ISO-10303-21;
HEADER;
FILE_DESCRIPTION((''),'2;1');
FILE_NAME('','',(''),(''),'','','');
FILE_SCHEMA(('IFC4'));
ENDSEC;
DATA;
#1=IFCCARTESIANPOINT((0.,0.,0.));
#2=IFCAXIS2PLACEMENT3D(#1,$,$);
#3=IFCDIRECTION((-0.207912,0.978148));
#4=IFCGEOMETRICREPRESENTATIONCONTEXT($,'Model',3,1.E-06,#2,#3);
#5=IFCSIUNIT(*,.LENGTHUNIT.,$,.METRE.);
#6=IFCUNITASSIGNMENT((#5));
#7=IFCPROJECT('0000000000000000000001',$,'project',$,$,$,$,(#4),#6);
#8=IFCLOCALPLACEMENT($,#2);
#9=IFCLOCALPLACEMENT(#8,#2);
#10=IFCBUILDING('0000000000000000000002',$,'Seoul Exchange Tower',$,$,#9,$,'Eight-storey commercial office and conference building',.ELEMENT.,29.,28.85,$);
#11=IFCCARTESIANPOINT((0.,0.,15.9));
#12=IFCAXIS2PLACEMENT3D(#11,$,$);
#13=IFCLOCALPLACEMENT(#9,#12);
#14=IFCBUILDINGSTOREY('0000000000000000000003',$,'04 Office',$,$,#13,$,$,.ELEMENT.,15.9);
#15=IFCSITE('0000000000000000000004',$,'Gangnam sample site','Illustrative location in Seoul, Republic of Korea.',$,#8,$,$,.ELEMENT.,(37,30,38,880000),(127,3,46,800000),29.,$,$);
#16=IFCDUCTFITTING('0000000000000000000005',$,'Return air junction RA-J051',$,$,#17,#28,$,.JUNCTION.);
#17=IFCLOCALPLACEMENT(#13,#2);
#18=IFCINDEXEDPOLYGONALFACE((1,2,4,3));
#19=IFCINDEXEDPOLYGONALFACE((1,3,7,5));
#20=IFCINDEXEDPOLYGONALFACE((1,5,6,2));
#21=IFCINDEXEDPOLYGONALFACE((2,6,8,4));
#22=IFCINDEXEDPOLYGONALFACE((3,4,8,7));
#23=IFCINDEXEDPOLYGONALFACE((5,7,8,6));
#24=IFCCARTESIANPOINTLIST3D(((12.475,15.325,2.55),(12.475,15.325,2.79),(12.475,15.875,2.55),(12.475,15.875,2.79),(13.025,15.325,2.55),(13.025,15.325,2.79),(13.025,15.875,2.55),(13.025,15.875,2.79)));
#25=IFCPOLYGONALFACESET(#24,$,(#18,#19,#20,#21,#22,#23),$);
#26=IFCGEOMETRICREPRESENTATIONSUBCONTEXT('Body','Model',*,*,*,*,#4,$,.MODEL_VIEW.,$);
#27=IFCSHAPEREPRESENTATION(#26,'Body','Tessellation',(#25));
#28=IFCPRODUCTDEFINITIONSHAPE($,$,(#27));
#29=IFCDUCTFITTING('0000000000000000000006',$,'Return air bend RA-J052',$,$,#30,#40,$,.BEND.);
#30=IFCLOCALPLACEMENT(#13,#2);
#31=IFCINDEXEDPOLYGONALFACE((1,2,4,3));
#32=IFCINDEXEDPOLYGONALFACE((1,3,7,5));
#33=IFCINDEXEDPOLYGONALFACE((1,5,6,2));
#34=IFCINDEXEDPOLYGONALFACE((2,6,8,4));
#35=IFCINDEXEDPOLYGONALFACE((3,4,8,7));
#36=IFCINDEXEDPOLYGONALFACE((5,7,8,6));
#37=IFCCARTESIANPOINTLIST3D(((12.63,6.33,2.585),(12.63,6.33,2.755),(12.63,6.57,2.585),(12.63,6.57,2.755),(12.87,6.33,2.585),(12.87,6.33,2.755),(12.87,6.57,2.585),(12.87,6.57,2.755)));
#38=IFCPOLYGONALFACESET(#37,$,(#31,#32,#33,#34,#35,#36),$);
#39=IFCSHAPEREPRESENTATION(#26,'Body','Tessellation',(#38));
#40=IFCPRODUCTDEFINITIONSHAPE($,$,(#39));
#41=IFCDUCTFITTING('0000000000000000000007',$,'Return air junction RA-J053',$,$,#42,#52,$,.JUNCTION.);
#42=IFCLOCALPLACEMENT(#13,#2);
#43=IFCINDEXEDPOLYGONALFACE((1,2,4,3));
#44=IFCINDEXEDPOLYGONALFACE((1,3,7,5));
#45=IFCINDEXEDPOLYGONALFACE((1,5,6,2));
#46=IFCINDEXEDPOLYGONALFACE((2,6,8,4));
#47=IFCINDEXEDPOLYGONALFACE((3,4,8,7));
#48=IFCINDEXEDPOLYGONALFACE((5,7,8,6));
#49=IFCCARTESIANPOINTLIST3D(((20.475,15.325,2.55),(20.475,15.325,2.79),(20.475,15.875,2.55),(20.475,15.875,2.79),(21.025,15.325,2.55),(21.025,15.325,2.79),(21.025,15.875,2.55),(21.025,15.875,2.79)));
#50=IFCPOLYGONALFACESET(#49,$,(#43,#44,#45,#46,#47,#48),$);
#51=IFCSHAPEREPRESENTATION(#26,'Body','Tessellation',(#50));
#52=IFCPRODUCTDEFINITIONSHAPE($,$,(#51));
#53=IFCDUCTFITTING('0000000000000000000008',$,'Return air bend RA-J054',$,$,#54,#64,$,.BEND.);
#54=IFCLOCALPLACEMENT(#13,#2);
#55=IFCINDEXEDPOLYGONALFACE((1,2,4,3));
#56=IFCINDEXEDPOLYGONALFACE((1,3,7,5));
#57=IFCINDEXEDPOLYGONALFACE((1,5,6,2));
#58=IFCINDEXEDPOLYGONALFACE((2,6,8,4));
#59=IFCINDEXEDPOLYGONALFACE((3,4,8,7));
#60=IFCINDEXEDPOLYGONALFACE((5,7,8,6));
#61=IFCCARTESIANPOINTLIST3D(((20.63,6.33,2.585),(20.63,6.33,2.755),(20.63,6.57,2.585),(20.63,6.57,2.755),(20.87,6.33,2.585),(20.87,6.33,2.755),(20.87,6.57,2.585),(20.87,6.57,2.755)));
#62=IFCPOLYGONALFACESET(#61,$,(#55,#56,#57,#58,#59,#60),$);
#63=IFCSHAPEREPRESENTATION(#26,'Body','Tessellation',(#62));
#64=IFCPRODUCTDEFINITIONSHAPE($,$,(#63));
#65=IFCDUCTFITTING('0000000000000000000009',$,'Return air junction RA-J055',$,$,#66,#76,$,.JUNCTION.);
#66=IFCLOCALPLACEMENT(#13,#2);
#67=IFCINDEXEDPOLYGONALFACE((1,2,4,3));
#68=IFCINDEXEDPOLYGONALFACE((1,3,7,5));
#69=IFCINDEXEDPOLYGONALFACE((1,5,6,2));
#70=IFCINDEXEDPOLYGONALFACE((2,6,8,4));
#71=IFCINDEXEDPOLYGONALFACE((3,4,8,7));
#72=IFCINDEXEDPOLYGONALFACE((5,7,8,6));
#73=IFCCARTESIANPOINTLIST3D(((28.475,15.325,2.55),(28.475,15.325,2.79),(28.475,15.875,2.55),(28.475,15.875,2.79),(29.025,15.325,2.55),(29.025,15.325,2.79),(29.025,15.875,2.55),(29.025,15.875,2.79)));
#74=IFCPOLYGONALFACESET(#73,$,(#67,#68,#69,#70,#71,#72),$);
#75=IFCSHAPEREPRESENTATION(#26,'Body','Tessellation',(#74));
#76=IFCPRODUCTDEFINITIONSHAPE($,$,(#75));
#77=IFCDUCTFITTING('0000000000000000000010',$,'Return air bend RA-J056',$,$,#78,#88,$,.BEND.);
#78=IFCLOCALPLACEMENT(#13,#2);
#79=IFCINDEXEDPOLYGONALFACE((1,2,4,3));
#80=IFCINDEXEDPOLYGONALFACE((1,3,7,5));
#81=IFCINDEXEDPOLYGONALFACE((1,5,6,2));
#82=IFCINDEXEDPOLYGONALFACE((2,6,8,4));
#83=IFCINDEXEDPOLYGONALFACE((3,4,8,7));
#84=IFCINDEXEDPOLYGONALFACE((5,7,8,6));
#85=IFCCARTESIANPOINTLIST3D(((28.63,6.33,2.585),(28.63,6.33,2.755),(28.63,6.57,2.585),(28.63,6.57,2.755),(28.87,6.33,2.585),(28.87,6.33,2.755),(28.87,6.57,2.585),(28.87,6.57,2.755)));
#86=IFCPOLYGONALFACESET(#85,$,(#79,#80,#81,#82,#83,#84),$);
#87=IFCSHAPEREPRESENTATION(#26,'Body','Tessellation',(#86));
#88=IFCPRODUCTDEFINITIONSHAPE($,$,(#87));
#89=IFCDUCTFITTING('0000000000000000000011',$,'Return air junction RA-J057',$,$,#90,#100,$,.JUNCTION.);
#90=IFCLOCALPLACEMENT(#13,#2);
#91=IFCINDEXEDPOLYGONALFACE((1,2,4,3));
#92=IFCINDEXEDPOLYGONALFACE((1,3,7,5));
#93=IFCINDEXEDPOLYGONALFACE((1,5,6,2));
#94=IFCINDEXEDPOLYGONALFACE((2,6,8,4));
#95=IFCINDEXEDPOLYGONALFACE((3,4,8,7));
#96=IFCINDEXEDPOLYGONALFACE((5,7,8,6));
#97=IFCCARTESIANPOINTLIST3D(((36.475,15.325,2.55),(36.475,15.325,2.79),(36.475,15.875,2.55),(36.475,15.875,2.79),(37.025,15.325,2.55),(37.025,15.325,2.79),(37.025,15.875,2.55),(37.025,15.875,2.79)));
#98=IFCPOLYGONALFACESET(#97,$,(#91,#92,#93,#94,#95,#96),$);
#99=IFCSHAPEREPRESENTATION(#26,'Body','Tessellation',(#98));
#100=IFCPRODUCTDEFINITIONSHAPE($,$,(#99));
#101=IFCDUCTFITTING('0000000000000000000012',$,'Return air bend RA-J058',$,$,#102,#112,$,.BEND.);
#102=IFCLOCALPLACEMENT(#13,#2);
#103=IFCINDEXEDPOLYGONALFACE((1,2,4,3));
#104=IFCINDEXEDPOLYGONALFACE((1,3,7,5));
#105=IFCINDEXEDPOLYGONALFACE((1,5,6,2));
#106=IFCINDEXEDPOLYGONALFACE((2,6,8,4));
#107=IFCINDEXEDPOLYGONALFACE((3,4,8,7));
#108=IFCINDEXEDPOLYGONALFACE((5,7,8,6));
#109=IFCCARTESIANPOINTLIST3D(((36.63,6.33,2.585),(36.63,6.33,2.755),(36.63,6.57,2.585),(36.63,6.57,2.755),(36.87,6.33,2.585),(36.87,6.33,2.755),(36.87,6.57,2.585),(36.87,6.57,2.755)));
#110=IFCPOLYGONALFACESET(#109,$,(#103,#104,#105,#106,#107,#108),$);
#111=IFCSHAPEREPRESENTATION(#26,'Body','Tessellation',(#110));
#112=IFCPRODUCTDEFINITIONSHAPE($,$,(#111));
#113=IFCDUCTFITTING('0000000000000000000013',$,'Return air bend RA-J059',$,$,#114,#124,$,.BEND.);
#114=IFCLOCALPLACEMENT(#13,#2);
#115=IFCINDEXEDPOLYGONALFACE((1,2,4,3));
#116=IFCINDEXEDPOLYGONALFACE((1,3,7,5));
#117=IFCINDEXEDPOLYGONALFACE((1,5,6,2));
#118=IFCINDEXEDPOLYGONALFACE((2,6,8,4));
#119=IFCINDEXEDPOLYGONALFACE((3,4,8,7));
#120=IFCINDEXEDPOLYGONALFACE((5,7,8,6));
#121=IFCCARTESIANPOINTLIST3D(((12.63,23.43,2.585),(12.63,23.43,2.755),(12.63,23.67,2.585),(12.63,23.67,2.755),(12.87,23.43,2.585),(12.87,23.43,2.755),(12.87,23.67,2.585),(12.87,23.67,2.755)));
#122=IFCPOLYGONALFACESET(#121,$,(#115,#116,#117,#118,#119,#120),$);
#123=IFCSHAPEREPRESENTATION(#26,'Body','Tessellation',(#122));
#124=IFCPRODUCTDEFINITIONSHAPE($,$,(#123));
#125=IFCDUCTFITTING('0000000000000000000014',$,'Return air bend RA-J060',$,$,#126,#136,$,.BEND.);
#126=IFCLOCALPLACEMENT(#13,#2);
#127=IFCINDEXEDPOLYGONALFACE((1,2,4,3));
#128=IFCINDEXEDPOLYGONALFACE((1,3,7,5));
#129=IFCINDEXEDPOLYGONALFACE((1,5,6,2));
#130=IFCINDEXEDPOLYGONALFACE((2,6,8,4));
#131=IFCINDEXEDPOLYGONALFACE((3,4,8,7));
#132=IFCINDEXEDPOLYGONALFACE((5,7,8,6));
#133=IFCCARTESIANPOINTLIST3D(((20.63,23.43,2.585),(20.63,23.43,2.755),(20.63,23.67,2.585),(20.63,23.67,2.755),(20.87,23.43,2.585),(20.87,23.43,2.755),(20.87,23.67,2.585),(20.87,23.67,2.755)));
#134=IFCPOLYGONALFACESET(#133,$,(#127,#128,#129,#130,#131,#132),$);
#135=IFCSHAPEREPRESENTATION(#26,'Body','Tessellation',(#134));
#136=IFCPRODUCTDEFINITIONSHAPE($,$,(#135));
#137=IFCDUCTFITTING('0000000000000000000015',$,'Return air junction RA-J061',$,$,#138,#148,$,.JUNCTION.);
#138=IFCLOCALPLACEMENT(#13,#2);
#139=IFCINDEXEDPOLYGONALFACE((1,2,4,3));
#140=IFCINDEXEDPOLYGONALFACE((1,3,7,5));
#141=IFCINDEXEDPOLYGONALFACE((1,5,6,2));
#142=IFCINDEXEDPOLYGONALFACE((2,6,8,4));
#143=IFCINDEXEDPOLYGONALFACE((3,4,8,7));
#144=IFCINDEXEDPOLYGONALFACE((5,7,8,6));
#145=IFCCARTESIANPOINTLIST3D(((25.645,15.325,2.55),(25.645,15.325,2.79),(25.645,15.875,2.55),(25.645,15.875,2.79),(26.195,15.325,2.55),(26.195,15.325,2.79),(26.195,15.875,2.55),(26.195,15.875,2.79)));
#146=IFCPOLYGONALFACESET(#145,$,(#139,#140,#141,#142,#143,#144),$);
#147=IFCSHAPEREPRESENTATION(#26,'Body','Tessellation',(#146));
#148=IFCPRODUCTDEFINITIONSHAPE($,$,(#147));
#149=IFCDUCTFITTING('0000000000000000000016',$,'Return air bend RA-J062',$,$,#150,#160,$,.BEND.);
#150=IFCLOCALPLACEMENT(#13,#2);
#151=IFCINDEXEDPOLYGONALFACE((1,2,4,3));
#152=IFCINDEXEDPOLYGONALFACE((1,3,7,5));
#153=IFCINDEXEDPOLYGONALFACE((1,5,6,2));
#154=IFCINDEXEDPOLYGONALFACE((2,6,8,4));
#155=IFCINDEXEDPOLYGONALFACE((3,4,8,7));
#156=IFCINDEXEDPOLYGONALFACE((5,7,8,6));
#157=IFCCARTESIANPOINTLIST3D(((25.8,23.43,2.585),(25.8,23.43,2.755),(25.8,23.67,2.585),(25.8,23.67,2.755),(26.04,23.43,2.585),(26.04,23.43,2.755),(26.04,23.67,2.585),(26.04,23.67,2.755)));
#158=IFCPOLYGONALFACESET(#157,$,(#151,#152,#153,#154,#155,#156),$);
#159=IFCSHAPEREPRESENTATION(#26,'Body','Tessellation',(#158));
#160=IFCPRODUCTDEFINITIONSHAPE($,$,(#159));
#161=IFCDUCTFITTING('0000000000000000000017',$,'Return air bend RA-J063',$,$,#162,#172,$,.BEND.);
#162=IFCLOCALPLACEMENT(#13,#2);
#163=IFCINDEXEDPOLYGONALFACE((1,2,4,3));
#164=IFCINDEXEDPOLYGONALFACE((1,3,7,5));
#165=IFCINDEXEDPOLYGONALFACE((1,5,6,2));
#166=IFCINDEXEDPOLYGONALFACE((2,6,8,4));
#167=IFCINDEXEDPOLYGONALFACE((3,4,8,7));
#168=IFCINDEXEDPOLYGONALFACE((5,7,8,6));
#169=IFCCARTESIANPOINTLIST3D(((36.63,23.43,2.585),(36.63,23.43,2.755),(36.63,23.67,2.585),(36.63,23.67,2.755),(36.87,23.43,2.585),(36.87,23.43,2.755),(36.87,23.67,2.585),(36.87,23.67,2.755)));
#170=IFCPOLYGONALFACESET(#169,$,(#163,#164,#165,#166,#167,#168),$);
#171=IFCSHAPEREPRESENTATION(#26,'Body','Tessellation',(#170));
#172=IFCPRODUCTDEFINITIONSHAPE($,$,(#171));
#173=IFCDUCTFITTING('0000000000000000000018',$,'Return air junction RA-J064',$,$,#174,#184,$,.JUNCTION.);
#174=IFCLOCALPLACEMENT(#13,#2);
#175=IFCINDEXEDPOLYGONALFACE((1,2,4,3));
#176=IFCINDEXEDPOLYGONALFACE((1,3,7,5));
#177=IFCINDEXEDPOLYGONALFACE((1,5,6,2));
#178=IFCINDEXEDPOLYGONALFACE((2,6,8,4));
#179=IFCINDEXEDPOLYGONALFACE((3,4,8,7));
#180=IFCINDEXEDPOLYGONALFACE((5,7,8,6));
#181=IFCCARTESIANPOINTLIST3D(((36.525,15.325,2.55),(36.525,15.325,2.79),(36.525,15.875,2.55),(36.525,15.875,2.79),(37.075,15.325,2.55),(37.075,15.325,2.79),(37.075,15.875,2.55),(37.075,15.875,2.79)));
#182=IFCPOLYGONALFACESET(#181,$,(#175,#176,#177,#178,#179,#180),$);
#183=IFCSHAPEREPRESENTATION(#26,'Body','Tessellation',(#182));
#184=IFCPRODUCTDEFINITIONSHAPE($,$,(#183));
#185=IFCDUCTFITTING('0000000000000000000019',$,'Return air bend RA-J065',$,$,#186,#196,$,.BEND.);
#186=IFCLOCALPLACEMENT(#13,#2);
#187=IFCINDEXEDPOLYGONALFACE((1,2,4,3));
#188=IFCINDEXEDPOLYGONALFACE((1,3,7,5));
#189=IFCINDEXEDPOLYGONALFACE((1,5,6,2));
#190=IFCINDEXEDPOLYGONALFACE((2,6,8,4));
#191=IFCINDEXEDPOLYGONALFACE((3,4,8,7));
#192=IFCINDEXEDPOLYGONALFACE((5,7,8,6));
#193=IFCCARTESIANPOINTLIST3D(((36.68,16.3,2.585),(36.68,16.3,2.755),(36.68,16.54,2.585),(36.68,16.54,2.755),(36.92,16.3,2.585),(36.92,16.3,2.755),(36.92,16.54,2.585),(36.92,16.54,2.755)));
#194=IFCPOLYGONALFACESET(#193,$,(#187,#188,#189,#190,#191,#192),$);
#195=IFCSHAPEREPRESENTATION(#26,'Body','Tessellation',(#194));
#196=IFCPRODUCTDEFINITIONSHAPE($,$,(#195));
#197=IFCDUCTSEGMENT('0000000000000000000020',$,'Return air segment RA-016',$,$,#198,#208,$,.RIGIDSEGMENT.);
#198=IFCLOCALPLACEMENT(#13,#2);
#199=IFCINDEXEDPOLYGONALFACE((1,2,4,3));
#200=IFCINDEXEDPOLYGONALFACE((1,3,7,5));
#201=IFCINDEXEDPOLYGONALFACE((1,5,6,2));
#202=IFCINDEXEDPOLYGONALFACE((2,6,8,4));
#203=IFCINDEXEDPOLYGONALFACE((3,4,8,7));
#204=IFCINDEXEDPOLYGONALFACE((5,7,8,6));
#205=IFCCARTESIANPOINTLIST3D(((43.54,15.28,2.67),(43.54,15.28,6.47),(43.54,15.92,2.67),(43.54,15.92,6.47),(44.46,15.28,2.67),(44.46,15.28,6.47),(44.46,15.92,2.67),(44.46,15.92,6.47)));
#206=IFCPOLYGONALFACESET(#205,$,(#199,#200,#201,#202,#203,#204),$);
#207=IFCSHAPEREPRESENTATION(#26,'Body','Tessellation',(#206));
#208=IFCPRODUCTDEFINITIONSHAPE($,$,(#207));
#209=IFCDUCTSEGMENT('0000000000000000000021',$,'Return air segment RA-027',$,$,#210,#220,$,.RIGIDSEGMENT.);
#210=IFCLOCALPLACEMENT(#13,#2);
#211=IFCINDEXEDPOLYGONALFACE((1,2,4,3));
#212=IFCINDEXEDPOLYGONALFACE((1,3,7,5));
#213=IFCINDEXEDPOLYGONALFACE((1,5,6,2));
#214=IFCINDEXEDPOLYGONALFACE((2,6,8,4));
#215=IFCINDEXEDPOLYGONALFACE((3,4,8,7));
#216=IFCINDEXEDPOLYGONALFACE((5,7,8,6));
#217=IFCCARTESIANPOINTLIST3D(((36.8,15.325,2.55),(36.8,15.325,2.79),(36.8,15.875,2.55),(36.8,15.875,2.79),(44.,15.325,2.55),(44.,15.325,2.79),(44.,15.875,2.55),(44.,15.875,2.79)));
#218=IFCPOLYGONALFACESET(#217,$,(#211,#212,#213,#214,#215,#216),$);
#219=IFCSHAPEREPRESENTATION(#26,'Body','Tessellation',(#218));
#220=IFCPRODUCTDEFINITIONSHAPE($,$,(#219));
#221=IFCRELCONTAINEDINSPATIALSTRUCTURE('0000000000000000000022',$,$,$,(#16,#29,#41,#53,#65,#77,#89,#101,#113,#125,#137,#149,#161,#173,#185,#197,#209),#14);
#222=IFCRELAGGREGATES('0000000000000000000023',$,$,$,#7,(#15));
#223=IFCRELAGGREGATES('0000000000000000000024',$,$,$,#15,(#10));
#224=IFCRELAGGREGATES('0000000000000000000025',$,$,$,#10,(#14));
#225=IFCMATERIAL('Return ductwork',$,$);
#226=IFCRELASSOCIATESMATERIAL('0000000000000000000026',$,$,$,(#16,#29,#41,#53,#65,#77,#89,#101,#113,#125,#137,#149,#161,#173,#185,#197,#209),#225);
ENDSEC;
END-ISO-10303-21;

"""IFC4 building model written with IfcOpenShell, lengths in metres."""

from ifc_helpers import new_model, si_unit, direction, frame, frame_2d, origin, place, context, subcontext, project, spatial, rectangle, extrude, material, element, save


model = new_model("IFC4")

# Units and contexts
model_context = context("Model", 3, precision=1e-06, world=origin(), true_north=direction((-0.207912, 0.978148)))
body_context = subcontext(model_context, "Body", "Model", "MODEL_VIEW")
ifc_project = project(units=[si_unit("LENGTHUNIT", "METRE")], contexts=[model_context])

# Site, building, storey
site_placement = place(None, origin())
site = spatial("IfcSite", under=ifc_project, at=site_placement, Name="Gangnam sample site", Description="Illustrative location in Seoul, Republic of Korea.", CompositionType="ELEMENT", RefLatitude=(37, 30, 38, 880000), RefLongitude=(127, 3, 46, 800000), RefElevation=29.0)
building_placement = place(site_placement, origin())
building = spatial("IfcBuilding", under=site, at=building_placement, Name="Seoul Exchange Tower", LongName="Eight-storey commercial office and conference building", CompositionType="ELEMENT", ElevationOfRefHeight=29.0, ElevationOfTerrain=28.85)
storey_placement = place(building_placement, frame((0.0, 0.0, 15.9)))
storey = spatial("IfcBuildingStorey", under=building, at=storey_placement, Name="04 Office", CompositionType="ELEMENT", Elevation=15.9)

# Duct fittings
ifc_material = material(Name="Return ductwork")
placement = place(storey_placement, origin())
element("IfcDuctFitting", 1, at=placement, inside=storey, material=ifc_material, Name="Return air junction RA-J051", PredefinedType="JUNCTION", context=body_context, shape_type="SweptSolid", body=[
    extrude(rectangle(XDim=0.55, YDim=0.55, at=frame_2d((0.275, 0.275))), frame((12.475, 15.325, 2.55)), (0.0, 0.0, 1.0), 0.24),
])
element("IfcDuctFitting", 2, at=placement, inside=storey, material=ifc_material, Name="Return air bend RA-J052", PredefinedType="BEND", context=body_context, shape_type="SweptSolid", body=[
    extrude(rectangle(XDim=0.24, YDim=0.24, at=frame_2d((0.12, 0.12))), frame((12.63, 6.33, 2.585)), (0.0, 0.0, 1.0), 0.17),
])
element("IfcDuctFitting", 3, at=placement, inside=storey, material=ifc_material, Name="Return air junction RA-J053", PredefinedType="JUNCTION", context=body_context, shape_type="SweptSolid", body=[
    extrude(rectangle(XDim=0.55, YDim=0.55, at=frame_2d((0.275, 0.275))), frame((20.475, 15.325, 2.55)), (0.0, 0.0, 1.0), 0.24),
])
element("IfcDuctFitting", 4, at=placement, inside=storey, material=ifc_material, Name="Return air bend RA-J054", PredefinedType="BEND", context=body_context, shape_type="SweptSolid", body=[
    extrude(rectangle(XDim=0.24, YDim=0.24, at=frame_2d((0.12, 0.12))), frame((20.63, 6.33, 2.585)), (0.0, 0.0, 1.0), 0.17),
])
element("IfcDuctFitting", 5, at=placement, inside=storey, material=ifc_material, Name="Return air junction RA-J055", PredefinedType="JUNCTION", context=body_context, shape_type="SweptSolid", body=[
    extrude(rectangle(XDim=0.55, YDim=0.55, at=frame_2d((0.275, 0.275))), frame((28.475, 15.325, 2.55)), (0.0, 0.0, 1.0), 0.24),
])
element("IfcDuctFitting", 6, at=placement, inside=storey, material=ifc_material, Name="Return air bend RA-J056", PredefinedType="BEND", context=body_context, shape_type="SweptSolid", body=[
    extrude(rectangle(XDim=0.24, YDim=0.24, at=frame_2d((0.12, 0.12))), frame((28.63, 6.33, 2.585)), (0.0, 0.0, 1.0), 0.17),
])
element("IfcDuctFitting", 7, at=placement, inside=storey, material=ifc_material, Name="Return air junction RA-J057", PredefinedType="JUNCTION", context=body_context, shape_type="SweptSolid", body=[
    extrude(rectangle(XDim=0.55, YDim=0.55, at=frame_2d((0.275, 0.275))), frame((36.475, 15.325, 2.55)), (0.0, 0.0, 1.0), 0.24),
])
element("IfcDuctFitting", 8, at=placement, inside=storey, material=ifc_material, Name="Return air bend RA-J058", PredefinedType="BEND", context=body_context, shape_type="SweptSolid", body=[
    extrude(rectangle(XDim=0.24, YDim=0.24, at=frame_2d((0.12, 0.12))), frame((36.63, 6.33, 2.585)), (0.0, 0.0, 1.0), 0.17),
])
element("IfcDuctFitting", 9, at=placement, inside=storey, material=ifc_material, Name="Return air bend RA-J059", PredefinedType="BEND", context=body_context, shape_type="SweptSolid", body=[
    extrude(rectangle(XDim=0.24, YDim=0.24, at=frame_2d((0.12, 0.12))), frame((12.63, 23.43, 2.585)), (0.0, 0.0, 1.0), 0.17),
])
element("IfcDuctFitting", 10, at=placement, inside=storey, material=ifc_material, Name="Return air bend RA-J060", PredefinedType="BEND", context=body_context, shape_type="SweptSolid", body=[
    extrude(rectangle(XDim=0.24, YDim=0.24, at=frame_2d((0.12, 0.12))), frame((20.63, 23.43, 2.585)), (0.0, 0.0, 1.0), 0.17),
])
element("IfcDuctFitting", 11, at=placement, inside=storey, material=ifc_material, Name="Return air junction RA-J061", PredefinedType="JUNCTION", context=body_context, shape_type="SweptSolid", body=[
    extrude(rectangle(XDim=0.55, YDim=0.55, at=frame_2d((0.275, 0.275))), frame((25.645, 15.325, 2.55)), (0.0, 0.0, 1.0), 0.24),
])
element("IfcDuctFitting", 12, at=placement, inside=storey, material=ifc_material, Name="Return air bend RA-J062", PredefinedType="BEND", context=body_context, shape_type="SweptSolid", body=[
    extrude(rectangle(XDim=0.24, YDim=0.24, at=frame_2d((0.12, 0.12))), frame((25.8, 23.43, 2.585)), (0.0, 0.0, 1.0), 0.17),
])
element("IfcDuctFitting", 13, at=placement, inside=storey, material=ifc_material, Name="Return air bend RA-J063", PredefinedType="BEND", context=body_context, shape_type="SweptSolid", body=[
    extrude(rectangle(XDim=0.24, YDim=0.24, at=frame_2d((0.12, 0.12))), frame((36.63, 23.43, 2.585)), (0.0, 0.0, 1.0), 0.17),
])
element("IfcDuctFitting", 14, at=placement, inside=storey, material=ifc_material, Name="Return air junction RA-J064", PredefinedType="JUNCTION", context=body_context, shape_type="SweptSolid", body=[
    extrude(rectangle(XDim=0.55, YDim=0.55, at=frame_2d((0.275, 0.275))), frame((36.525, 15.325, 2.55)), (0.0, 0.0, 1.0), 0.24),
])
element("IfcDuctFitting", 15, at=placement, inside=storey, material=ifc_material, Name="Return air bend RA-J065", PredefinedType="BEND", context=body_context, shape_type="SweptSolid", body=[
    extrude(rectangle(XDim=0.24, YDim=0.24, at=frame_2d((0.12, 0.12))), frame((36.68, 16.3, 2.585)), (0.0, 0.0, 1.0), 0.17),
])

# Duct segments
element("IfcDuctSegment", 16, at=placement, inside=storey, material=ifc_material, Name="Return air segment RA-016", PredefinedType="RIGIDSEGMENT", context=body_context, shape_type="SweptSolid", body=[
    extrude(rectangle(XDim=0.92, YDim=0.64), frame((44.0, 15.6, 2.67), z_axis=(0.0, 0.0, 1.0), x_axis=(1.0, 0.0, 0.0)), (0.0, 0.0, 1.0), 3.8),
])
element("IfcDuctSegment", 17, at=placement, inside=storey, material=ifc_material, Name="Return air segment RA-027", PredefinedType="RIGIDSEGMENT", context=body_context, shape_type="SweptSolid", body=[
    extrude(rectangle(XDim=0.55, YDim=0.24), frame((36.8, 15.6, 2.67), z_axis=(1.0, 0.0, 0.0), x_axis=(0.0, 1.0, 0.0)), (0.0, 0.0, 1.0), 7.2),
])

save(model, "model.ifc")
